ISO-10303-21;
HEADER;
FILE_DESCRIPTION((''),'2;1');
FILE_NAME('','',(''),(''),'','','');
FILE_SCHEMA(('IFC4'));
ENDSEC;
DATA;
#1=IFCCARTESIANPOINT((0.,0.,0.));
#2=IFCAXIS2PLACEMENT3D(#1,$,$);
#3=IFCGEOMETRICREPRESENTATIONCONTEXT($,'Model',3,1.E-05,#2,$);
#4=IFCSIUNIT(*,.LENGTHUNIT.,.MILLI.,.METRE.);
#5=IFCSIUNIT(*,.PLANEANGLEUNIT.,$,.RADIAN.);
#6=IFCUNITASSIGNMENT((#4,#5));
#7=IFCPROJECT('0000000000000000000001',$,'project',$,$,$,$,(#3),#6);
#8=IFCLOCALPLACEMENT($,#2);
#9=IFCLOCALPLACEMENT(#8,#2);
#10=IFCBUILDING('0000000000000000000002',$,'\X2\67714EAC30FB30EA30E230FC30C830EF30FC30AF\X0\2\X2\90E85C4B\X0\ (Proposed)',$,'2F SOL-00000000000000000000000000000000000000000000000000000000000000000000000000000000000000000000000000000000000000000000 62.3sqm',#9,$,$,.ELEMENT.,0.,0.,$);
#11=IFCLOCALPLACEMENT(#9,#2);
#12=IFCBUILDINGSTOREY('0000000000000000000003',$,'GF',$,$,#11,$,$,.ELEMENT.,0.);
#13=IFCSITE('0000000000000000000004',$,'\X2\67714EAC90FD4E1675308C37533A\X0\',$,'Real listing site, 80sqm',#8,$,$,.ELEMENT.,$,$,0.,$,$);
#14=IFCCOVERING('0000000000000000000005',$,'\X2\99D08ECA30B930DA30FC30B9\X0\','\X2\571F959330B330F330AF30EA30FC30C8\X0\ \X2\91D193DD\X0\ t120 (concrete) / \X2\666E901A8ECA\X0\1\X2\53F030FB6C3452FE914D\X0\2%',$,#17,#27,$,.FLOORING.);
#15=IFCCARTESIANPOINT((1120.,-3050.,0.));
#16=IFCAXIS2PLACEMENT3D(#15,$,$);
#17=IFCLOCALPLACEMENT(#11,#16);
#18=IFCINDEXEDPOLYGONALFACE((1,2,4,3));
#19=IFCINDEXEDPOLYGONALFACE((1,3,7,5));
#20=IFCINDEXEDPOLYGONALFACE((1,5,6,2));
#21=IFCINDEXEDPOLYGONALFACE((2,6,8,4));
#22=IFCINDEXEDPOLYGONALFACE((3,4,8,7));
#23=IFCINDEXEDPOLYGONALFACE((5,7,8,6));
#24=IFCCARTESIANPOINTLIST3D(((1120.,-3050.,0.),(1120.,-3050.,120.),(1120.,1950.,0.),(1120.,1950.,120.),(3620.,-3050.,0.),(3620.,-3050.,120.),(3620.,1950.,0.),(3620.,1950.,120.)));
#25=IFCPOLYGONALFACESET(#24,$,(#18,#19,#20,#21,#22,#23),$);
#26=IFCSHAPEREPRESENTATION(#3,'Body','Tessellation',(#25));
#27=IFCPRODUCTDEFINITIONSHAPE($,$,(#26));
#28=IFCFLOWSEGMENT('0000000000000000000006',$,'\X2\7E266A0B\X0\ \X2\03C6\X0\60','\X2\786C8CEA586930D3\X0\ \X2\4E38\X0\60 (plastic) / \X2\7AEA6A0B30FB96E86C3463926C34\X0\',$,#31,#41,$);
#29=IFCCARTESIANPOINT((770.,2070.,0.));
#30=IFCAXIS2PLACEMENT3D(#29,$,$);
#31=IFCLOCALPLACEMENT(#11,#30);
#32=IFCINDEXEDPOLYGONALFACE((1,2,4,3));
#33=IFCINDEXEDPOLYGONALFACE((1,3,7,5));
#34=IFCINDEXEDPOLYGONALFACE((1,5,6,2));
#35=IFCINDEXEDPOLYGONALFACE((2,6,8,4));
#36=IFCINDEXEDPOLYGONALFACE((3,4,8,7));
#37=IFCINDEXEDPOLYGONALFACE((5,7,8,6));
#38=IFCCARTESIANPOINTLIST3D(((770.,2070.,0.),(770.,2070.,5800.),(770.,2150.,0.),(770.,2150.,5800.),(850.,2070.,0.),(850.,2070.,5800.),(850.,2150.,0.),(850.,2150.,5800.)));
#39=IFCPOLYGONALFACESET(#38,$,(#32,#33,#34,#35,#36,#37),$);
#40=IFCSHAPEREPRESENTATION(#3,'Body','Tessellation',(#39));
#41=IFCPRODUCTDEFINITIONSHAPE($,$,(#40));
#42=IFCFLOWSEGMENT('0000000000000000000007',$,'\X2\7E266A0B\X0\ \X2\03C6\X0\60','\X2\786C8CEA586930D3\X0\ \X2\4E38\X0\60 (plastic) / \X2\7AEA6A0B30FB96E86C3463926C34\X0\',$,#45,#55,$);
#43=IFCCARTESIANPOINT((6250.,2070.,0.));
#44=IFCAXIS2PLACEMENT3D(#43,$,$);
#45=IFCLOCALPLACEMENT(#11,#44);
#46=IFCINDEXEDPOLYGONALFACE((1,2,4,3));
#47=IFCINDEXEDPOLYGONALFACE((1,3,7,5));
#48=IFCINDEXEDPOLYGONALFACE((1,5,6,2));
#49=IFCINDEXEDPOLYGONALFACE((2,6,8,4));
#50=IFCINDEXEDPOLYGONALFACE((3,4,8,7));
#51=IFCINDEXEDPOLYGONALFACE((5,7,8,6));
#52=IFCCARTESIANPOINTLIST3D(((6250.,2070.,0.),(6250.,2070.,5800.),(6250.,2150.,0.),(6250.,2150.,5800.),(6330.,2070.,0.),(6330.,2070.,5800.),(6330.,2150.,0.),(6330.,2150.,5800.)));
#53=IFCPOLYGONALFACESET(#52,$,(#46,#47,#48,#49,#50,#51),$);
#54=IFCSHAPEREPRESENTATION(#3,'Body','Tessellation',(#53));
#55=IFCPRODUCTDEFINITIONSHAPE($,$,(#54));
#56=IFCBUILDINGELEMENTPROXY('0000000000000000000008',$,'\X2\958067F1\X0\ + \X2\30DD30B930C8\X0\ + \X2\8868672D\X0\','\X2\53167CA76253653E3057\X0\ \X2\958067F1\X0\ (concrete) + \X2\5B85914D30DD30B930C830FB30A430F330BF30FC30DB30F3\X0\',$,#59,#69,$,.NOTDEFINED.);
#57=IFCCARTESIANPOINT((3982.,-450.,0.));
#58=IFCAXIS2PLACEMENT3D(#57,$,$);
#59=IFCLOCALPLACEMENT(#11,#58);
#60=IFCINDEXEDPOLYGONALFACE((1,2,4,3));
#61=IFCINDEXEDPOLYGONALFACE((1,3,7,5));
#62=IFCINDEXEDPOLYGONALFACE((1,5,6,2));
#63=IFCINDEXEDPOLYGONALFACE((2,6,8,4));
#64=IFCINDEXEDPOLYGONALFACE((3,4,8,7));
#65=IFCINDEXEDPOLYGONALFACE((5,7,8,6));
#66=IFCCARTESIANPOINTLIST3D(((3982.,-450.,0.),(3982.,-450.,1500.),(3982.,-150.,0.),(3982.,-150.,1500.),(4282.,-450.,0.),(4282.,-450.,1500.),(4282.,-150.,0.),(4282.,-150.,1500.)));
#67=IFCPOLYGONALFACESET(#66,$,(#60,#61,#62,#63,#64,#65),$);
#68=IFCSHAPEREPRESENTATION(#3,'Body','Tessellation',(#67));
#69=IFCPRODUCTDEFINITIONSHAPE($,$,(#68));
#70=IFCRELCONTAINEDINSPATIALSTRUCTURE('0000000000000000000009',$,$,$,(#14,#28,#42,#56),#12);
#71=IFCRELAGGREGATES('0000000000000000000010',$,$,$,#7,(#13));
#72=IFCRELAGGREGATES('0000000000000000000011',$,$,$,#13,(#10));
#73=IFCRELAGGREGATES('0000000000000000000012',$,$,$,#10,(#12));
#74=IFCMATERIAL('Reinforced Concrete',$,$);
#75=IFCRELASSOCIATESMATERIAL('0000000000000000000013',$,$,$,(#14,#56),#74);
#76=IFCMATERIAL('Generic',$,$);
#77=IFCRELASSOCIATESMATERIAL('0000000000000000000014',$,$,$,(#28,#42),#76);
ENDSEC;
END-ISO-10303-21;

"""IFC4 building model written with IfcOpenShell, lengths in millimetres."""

from ifc_helpers import new_model, si_unit, frame, frame_2d, origin, place, context, project, spatial, rectangle, extrude, material, element, save


model = new_model("IFC4")

# Units and contexts
model_context = context("Model", 3, precision=1e-05, world=origin())
ifc_project = project(units=[si_unit("LENGTHUNIT", "METRE", prefix="MILLI"), si_unit("PLANEANGLEUNIT", "RADIAN")], contexts=[model_context])

# Site, building, storey
site_placement = place(None, origin())
site = spatial("IfcSite", under=ifc_project, at=site_placement, Name="東京都世田谷区", ObjectType="Real listing site, 80sqm", CompositionType="ELEMENT", RefElevation=0.0)
building_placement = place(site_placement, origin())
building = spatial("IfcBuilding", under=site, at=building_placement, Name="東京・リモートワーク2部屋 (Proposed)", ObjectType="2F SOL-00000000000000000000000000000000000000000000000000000000000000000000000000000000000000000000000000000000000000000000 62.3sqm", CompositionType="ELEMENT", ElevationOfRefHeight=0.0, ElevationOfTerrain=0.0)
storey_placement = place(building_placement, origin())
storey = spatial("IfcBuildingStorey", under=building, at=storey_placement, Name="GF", CompositionType="ELEMENT", Elevation=0.0)

# Shared definitions
ifc_material_1 = material(Name="Reinforced Concrete")

# Covering
covering_1_placement = place(storey_placement, frame((1120.0, -3050.0, 0.0)))
element("IfcCovering", 1, at=covering_1_placement, inside=storey, material=ifc_material_1, Name="駐車スペース", Description="土間コンクリート 金鏝 t120 (concrete) / 普通車1台・水勾配2%", PredefinedType="FLOORING", context=model_context, shape_type="SweptSolid", body=[
    extrude(rectangle(XDim=2500.0, YDim=5000.0, at=frame_2d((1250.0, 2500.0))), frame((1120.0, -3050.0, 0.0)), (0.0, 0.0, 1.0), 120.0),
])

# Flow segments
ifc_material_2 = material(Name="Generic")
flow_segment_1_placement = place(storey_placement, frame((770.0, 2070.0, 0.0)))
element("IfcFlowSegment", 2, at=flow_segment_1_placement, inside=storey, material=ifc_material_2, Name="縦樋 φ60", Description="硬質塩ビ 丸60 (plastic) / 竪樋・雨水排水", context=model_context, shape_type="SweptSolid", body=[
    extrude(rectangle(XDim=80.0, YDim=80.0, at=frame_2d((40.0, 40.0))), frame((770.0, 2070.0, 0.0)), (0.0, 0.0, 1.0), 5800.0),
])
flow_segment_2_placement = place(storey_placement, frame((6250.0, 2070.0, 0.0)))
element("IfcFlowSegment", 3, at=flow_segment_2_placement, inside=storey, material=ifc_material_2, Name="縦樋 φ60", Description="硬質塩ビ 丸60 (plastic) / 竪樋・雨水排水", context=model_context, shape_type="SweptSolid", body=[
    extrude(rectangle(XDim=80.0, YDim=80.0, at=frame_2d((40.0, 40.0))), frame((6250.0, 2070.0, 0.0)), (0.0, 0.0, 1.0), 5800.0),
])

# Building element proxy
proxy_placement = place(storey_placement, frame((3982.0, -450.0, 0.0)))
element("IfcBuildingElementProxy", 4, at=proxy_placement, inside=storey, material=ifc_material_1, Name="門柱 + ポスト + 表札", Description="化粧打放し 門柱 (concrete) + 宅配ポスト・インターホン", PredefinedType="NOTDEFINED", context=model_context, shape_type="SweptSolid", body=[
    extrude(rectangle(XDim=300.0, YDim=300.0, at=frame_2d((150.0, 150.0))), frame((3982.0, -450.0, 0.0)), (0.0, 0.0, 1.0), 1500.0),
])

save(model, "model.ifc")
